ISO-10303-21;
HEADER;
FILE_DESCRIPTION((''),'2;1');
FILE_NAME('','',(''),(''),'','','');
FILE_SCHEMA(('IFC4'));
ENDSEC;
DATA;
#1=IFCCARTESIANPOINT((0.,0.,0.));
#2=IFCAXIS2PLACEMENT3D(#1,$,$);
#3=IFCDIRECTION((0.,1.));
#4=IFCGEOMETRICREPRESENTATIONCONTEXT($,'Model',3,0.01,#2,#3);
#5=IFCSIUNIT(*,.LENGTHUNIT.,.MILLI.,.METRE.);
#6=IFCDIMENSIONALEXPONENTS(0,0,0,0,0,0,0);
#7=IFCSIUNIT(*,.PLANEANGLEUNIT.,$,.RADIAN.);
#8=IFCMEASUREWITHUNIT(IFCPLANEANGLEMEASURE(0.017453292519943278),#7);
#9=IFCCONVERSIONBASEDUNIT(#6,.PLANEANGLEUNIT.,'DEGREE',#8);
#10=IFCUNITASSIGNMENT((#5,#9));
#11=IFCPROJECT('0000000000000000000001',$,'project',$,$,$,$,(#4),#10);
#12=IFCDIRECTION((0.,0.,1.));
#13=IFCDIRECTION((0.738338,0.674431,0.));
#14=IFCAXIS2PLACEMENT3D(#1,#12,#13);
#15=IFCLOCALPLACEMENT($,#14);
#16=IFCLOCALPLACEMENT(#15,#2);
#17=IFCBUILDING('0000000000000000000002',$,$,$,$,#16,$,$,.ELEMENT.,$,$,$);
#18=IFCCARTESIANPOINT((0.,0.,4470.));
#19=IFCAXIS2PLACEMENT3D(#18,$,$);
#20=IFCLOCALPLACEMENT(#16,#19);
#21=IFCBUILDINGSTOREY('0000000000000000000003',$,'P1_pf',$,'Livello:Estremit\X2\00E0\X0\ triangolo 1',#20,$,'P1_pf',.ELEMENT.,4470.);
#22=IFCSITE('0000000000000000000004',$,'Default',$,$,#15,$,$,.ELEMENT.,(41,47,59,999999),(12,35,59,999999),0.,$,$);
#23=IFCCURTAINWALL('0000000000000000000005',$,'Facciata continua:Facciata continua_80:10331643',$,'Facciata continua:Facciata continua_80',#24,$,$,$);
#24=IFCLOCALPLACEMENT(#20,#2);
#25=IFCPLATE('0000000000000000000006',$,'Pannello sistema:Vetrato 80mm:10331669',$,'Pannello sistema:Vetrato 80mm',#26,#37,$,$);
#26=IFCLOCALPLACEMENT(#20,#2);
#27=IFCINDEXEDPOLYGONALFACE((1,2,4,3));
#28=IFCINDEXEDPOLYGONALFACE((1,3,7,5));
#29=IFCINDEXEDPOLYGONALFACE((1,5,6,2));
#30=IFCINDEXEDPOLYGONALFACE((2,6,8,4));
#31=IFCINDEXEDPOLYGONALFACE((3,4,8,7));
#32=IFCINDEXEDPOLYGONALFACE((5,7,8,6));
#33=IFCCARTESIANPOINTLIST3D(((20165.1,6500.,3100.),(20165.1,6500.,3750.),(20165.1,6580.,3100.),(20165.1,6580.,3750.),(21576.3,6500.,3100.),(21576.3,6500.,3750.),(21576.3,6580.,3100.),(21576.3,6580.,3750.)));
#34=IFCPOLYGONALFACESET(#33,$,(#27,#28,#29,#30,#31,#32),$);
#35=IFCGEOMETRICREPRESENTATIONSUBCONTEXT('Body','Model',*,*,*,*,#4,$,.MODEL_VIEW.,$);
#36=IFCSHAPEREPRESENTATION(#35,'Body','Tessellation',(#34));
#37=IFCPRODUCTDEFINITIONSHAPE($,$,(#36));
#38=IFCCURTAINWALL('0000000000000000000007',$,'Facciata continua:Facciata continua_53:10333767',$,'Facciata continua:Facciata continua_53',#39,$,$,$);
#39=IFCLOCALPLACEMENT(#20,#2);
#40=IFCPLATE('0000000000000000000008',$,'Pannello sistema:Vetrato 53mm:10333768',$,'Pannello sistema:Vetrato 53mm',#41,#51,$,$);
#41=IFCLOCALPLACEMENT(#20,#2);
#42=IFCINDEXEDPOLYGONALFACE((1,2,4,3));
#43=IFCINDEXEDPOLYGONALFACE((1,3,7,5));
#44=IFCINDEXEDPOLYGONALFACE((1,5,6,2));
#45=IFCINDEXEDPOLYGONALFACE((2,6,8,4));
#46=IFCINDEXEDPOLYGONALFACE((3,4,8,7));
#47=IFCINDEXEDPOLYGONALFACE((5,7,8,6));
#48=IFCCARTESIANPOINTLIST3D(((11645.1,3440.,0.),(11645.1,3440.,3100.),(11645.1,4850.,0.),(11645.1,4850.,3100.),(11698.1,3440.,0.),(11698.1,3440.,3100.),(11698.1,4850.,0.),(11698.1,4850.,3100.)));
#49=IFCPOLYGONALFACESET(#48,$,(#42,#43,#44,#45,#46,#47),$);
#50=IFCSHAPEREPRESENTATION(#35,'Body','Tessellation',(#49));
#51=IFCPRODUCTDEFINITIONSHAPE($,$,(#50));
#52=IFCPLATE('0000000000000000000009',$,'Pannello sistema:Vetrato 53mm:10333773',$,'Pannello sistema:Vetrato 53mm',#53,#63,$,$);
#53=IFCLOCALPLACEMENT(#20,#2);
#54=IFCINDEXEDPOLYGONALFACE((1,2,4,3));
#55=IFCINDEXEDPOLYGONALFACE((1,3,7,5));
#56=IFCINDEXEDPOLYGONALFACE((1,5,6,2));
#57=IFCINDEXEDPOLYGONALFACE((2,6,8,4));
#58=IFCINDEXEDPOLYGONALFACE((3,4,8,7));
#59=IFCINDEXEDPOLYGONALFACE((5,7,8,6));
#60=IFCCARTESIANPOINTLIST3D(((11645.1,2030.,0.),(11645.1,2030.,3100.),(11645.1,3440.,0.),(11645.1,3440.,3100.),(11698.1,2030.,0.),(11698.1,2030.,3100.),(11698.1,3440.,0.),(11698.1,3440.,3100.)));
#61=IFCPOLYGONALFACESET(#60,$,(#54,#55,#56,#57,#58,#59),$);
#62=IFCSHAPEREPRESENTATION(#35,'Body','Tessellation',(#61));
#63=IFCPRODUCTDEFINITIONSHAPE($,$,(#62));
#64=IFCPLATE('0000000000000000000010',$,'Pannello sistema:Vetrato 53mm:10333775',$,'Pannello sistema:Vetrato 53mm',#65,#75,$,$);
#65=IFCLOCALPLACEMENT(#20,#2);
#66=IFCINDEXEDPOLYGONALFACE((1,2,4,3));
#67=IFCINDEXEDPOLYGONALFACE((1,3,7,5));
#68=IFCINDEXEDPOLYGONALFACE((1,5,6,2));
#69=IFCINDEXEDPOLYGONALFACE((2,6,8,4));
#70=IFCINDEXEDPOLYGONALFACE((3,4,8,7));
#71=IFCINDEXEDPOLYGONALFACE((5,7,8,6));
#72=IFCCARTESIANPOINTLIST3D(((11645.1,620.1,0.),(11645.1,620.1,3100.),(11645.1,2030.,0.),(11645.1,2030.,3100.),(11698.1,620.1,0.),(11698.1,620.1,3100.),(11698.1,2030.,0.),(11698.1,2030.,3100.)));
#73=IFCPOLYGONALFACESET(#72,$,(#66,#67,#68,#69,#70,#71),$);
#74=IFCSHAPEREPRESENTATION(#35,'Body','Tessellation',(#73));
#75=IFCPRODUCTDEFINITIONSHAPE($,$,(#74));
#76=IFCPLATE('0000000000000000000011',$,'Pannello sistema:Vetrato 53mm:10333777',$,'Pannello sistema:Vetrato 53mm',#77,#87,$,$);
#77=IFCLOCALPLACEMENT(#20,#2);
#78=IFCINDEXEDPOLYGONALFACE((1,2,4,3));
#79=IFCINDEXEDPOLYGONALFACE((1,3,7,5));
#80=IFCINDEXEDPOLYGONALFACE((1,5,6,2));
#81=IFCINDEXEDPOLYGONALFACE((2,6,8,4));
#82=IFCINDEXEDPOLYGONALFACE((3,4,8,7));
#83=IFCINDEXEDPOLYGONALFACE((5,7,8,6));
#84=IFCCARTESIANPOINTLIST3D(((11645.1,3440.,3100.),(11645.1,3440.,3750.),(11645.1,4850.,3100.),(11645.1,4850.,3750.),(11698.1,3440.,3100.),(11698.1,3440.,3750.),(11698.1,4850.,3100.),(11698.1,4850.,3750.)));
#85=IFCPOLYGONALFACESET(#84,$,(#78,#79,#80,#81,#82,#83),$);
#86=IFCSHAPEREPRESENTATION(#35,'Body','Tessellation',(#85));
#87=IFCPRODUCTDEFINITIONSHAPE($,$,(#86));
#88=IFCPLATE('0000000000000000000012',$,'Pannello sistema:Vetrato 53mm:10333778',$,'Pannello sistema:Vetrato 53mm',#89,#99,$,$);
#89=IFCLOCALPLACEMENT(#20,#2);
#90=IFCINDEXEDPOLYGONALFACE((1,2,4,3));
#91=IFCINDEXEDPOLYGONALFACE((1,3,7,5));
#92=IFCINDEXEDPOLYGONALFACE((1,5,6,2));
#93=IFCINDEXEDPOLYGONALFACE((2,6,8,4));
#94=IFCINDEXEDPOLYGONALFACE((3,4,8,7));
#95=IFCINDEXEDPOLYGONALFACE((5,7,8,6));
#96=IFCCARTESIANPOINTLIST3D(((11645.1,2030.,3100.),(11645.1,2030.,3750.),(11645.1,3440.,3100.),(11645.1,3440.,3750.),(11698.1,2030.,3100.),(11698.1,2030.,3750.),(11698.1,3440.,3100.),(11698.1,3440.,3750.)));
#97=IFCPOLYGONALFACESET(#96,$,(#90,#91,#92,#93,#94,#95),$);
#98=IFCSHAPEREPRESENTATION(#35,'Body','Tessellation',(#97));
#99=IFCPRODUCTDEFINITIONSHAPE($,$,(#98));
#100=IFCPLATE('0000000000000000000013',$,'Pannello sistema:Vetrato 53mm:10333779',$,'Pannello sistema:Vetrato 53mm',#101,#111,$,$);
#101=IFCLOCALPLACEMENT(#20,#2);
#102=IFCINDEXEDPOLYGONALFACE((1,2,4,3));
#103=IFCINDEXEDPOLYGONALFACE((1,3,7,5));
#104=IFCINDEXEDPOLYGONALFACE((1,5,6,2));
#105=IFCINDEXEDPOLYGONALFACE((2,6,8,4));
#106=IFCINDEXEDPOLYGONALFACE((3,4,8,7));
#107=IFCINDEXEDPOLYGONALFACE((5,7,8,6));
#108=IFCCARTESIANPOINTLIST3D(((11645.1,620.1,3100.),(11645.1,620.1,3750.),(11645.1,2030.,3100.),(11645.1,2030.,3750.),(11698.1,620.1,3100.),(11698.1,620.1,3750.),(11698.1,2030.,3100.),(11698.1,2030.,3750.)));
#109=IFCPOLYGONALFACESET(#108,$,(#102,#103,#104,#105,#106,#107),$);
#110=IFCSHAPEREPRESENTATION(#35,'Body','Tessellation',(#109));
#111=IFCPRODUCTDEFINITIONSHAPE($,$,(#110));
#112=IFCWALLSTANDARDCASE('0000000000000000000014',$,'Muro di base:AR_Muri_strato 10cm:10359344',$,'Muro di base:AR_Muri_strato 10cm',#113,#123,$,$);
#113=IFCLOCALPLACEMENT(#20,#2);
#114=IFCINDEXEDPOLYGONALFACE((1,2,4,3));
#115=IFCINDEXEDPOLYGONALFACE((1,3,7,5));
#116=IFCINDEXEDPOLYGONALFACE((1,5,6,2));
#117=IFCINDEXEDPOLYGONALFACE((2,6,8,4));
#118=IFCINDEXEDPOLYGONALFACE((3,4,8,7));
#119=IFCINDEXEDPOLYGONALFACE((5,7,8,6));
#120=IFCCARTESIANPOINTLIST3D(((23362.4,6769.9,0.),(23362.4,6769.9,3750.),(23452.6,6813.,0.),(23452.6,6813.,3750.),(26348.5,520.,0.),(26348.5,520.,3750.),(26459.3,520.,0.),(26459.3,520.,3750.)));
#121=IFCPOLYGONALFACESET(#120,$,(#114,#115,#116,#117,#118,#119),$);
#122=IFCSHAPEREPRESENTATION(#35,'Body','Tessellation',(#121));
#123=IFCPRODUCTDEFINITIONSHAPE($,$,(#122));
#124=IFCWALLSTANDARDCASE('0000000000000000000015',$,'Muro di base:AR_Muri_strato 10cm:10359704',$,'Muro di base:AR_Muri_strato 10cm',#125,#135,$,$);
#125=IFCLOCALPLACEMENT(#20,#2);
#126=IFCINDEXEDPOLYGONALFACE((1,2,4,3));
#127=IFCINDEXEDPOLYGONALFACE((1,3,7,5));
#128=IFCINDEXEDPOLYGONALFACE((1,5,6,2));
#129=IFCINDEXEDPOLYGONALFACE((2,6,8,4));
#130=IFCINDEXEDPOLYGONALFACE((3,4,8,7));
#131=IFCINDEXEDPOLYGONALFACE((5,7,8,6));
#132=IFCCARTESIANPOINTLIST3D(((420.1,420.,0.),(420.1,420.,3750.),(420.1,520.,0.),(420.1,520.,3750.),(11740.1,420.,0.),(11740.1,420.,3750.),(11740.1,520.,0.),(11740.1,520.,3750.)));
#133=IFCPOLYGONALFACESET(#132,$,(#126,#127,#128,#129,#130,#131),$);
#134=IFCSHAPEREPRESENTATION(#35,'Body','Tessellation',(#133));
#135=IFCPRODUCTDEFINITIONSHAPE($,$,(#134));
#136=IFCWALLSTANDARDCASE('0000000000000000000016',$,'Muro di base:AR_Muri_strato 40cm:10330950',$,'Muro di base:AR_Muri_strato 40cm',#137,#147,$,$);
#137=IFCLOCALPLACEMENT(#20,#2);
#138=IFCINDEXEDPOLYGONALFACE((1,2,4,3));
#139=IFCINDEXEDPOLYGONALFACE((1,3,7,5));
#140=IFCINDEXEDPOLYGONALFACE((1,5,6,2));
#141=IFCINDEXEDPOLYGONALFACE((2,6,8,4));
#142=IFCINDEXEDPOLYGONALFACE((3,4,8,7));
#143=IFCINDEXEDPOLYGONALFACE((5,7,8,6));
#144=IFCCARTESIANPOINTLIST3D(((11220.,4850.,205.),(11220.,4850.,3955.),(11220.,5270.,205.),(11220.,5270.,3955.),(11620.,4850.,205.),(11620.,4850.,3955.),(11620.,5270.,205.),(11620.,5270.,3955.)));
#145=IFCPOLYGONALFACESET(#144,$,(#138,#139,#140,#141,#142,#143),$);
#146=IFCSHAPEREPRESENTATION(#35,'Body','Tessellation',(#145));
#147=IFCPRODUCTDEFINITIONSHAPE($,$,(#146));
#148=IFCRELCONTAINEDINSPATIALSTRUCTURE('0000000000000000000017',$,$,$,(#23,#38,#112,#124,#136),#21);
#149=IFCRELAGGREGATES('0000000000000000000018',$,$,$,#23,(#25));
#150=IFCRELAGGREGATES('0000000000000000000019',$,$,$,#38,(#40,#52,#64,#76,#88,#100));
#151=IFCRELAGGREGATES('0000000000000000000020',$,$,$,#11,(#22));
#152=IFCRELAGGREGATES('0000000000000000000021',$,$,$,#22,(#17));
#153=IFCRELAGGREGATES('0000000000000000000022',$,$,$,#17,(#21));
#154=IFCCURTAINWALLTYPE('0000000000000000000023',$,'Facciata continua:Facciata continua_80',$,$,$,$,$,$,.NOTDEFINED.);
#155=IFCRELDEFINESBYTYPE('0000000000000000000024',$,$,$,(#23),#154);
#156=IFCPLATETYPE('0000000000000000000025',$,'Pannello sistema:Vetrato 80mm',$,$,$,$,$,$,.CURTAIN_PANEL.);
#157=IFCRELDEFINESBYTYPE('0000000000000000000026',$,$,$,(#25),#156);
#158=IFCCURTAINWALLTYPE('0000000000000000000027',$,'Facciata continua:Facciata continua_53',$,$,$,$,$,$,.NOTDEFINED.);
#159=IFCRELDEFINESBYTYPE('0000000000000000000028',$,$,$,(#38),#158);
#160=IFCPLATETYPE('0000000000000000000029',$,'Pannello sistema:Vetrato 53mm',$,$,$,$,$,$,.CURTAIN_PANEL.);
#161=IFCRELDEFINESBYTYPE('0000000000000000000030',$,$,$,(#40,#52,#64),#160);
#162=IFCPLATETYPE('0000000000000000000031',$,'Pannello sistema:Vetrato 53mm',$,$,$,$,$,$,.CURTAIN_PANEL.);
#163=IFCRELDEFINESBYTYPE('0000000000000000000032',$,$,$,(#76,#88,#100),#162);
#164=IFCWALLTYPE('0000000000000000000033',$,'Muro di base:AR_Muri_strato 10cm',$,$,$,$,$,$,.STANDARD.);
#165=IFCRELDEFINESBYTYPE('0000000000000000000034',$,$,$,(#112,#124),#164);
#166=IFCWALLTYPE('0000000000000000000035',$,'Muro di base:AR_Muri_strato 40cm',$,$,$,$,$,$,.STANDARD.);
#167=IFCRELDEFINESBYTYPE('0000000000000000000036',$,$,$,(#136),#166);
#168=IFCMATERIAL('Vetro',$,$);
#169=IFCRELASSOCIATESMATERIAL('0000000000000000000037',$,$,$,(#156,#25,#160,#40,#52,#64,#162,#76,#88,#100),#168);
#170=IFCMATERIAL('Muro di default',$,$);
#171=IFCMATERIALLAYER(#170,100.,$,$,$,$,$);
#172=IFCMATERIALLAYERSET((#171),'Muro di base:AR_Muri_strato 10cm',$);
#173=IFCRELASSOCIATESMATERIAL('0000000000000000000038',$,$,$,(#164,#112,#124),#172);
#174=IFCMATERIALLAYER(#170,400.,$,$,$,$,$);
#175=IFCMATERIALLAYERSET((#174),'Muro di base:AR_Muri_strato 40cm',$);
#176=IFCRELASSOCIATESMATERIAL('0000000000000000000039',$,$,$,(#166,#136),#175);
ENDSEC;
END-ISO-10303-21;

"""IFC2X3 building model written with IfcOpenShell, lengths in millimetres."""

from ifc_helpers import new_model, entity, si_unit, converted_unit, direction, frame, frame_2d, origin, origin_2d_with_axis, place, context, subcontext, project, spatial, polyline, rectangle, outline, extrude, source, transform, mapped, material, layer, layer_set, layer_usage, type_object, type_shapes, element, aggregate, save


model = new_model("IFC2X3")

# Units and contexts
model_context = context("Model", 3, precision=0.01, world=origin(), true_north=direction((0.0, 1.0)))
body_context = subcontext(model_context, "Body", "Model", "MODEL_VIEW")
ifc_project = project(units=[si_unit("LENGTHUNIT", "METRE", prefix="MILLI"), converted_unit("PLANEANGLEUNIT", "DEGREE", entity("IfcPlaneAngleMeasure", 0.017453292519943278), si_unit("PLANEANGLEUNIT", "RADIAN"), dimensions=[0, 0, 0, 0, 0, 0, 0])], contexts=[model_context])

# Site, building, storey
site_placement = place(None, frame((0.0, 0.0, 0.0), z_axis=(0.0, 0.0, 1.0), x_axis=(0.738338, 0.674431, 0.0)))
site = spatial("IfcSite", under=ifc_project, at=site_placement, Name="Default", CompositionType="ELEMENT", RefLatitude=(41, 47, 59, 999999), RefLongitude=(12, 35, 59, 999999), RefElevation=0.0)
building_placement = place(site_placement, origin())
building = spatial("IfcBuilding", under=site, at=building_placement, CompositionType="ELEMENT")
storey_placement = place(building_placement, frame((0.0, 0.0, 4470.0)))
storey = spatial("IfcBuildingStorey", under=building, at=storey_placement, Name="P1_pf", ObjectType="Livello:Estremità triangolo 1", LongName="P1_pf", CompositionType="ELEMENT", Elevation=4470.0)

# Shared definitions
ifc_material_1 = material(Name="Vetro")

# Curtain walls, plates
curtain_wall_type_1 = type_object("IfcCurtainWallType", Name="Facciata continua:Facciata continua_80", PredefinedType="NOTDEFINED")
curtain_wall_1_placement = place(storey_placement, frame((0.0, 0.0, -4470.0)))
curtain_wall_1 = element("IfcCurtainWall", 1, at=curtain_wall_1_placement, inside=storey, type_object=curtain_wall_type_1, Name="Facciata continua:Facciata continua_80:10331643", ObjectType="Facciata continua:Facciata continua_80")
plate_type_1 = type_object("IfcPlateType", Name="Pannello sistema:Vetrato 80mm", PredefinedType="CURTAIN_PANEL", material=ifc_material_1)
shared_shape_1 = source(origin(), body_context, "Body", "SweptSolid", [
    extrude(rectangle(XDim=80.0, YDim=1411.2, at=origin_2d_with_axis()), frame((0.0, -40.0, 0.0), z_axis=(0.0, 0.0, 1.0), x_axis=(0.0, 1.0, 0.0)), (0.0, 0.0, 1.0), 650.0),
])
type_shapes(plate_type_1, [shared_shape_1])
plate_1_placement = place(curtain_wall_1_placement, frame((20870.7, 6580.0, 7570.0)))
plate_1 = element("IfcPlate", 2, at=plate_1_placement, type_object=plate_type_1, material=ifc_material_1, Name="Pannello sistema:Vetrato 80mm:10331669", ObjectType="Pannello sistema:Vetrato 80mm", context=body_context, shape_type="MappedRepresentation", body=[
    mapped(shared_shape_1, transform((0.0, 0.0, 0.0), scale=1.0)),
])
aggregate(curtain_wall_1, [plate_1])
curtain_wall_type_2 = type_object("IfcCurtainWallType", Name="Facciata continua:Facciata continua_53", PredefinedType="NOTDEFINED")
curtain_wall_2_placement = place(storey_placement, frame((0.0, 0.0, -4470.0)))
curtain_wall_2 = element("IfcCurtainWall", 3, at=curtain_wall_2_placement, inside=storey, type_object=curtain_wall_type_2, Name="Facciata continua:Facciata continua_53:10333767", ObjectType="Facciata continua:Facciata continua_53")
plate_type_2 = type_object("IfcPlateType", Name="Pannello sistema:Vetrato 53mm", PredefinedType="CURTAIN_PANEL", material=ifc_material_1)
shared_shape_2 = source(origin(), body_context, "Body", "SweptSolid", [
    extrude(rectangle(XDim=53.0, YDim=1410.0, at=frame_2d((0.0, 0.0), x_axis=(1.0, 0.0))), frame((0.0, -26.5, 0.0), z_axis=(0.0, 0.0, 1.0), x_axis=(0.0, 1.0, 0.0)), (0.0, 0.0, 1.0), 3100.0),
])
type_shapes(plate_type_2, [shared_shape_2])
plate_2_placement = place(curtain_wall_2_placement, frame((11698.1, 4145.0, 4470.0), z_axis=(0.0, 0.0, 1.0), x_axis=(0.0, -1.0, 0.0)))
plate_2 = element("IfcPlate", 4, at=plate_2_placement, type_object=plate_type_2, material=ifc_material_1, Name="Pannello sistema:Vetrato 53mm:10333768", ObjectType="Pannello sistema:Vetrato 53mm", context=body_context, shape_type="MappedRepresentation", body=[
    mapped(shared_shape_2, transform((0.0, 0.0, 0.0), scale=1.0)),
])
plate_3_placement = place(curtain_wall_2_placement, frame((11698.1, 2735.0, 4470.0), z_axis=(0.0, 0.0, 1.0), x_axis=(0.0, -1.0, 0.0)))
plate_3 = element("IfcPlate", 5, at=plate_3_placement, type_object=plate_type_2, material=ifc_material_1, Name="Pannello sistema:Vetrato 53mm:10333773", ObjectType="Pannello sistema:Vetrato 53mm", context=body_context, shape_type="MappedRepresentation", body=[
    mapped(shared_shape_2, transform((0.0, 0.0, 0.0), scale=1.0)),
])
plate_4_placement = place(curtain_wall_2_placement, frame((11698.1, 1325.0, 4470.0), z_axis=(0.0, 0.0, 1.0), x_axis=(0.0, -1.0, 0.0)))
plate_4 = element("IfcPlate", 6, at=plate_4_placement, type_object=plate_type_2, material=ifc_material_1, Name="Pannello sistema:Vetrato 53mm:10333775", ObjectType="Pannello sistema:Vetrato 53mm", context=body_context, shape_type="MappedRepresentation", body=[
    mapped(shared_shape_2, transform((0.0, 0.0, 0.0), scale=1.0)),
])
plate_type_3 = type_object("IfcPlateType", Name="Pannello sistema:Vetrato 53mm", PredefinedType="CURTAIN_PANEL", material=ifc_material_1)
shared_shape_3 = source(origin(), body_context, "Body", "SweptSolid", [
    extrude(rectangle(XDim=53.0, YDim=1410.0, at=frame_2d((0.0, 0.0), x_axis=(1.0, 0.0))), frame((0.0, -26.5, 0.0), z_axis=(0.0, 0.0, 1.0), x_axis=(0.0, 1.0, 0.0)), (0.0, 0.0, 1.0), 650.0),
])
type_shapes(plate_type_3, [shared_shape_3])
plate_5_placement = place(curtain_wall_2_placement, frame((11698.1, 4145.0, 7570.0), z_axis=(0.0, 0.0, 1.0), x_axis=(0.0, -1.0, 0.0)))
plate_5 = element("IfcPlate", 7, at=plate_5_placement, type_object=plate_type_3, material=ifc_material_1, Name="Pannello sistema:Vetrato 53mm:10333777", ObjectType="Pannello sistema:Vetrato 53mm", context=body_context, shape_type="MappedRepresentation", body=[
    mapped(shared_shape_3, transform((0.0, 0.0, 0.0), scale=1.0)),
])
plate_6_placement = place(curtain_wall_2_placement, frame((11698.1, 2735.0, 7570.0), z_axis=(0.0, 0.0, 1.0), x_axis=(0.0, -1.0, 0.0)))
plate_6 = element("IfcPlate", 8, at=plate_6_placement, type_object=plate_type_3, material=ifc_material_1, Name="Pannello sistema:Vetrato 53mm:10333778", ObjectType="Pannello sistema:Vetrato 53mm", context=body_context, shape_type="MappedRepresentation", body=[
    mapped(shared_shape_3, transform((0.0, 0.0, 0.0), scale=1.0)),
])
plate_7_placement = place(curtain_wall_2_placement, frame((11698.1, 1325.0, 7570.0), z_axis=(0.0, 0.0, 1.0), x_axis=(0.0, -1.0, 0.0)))
plate_7 = element("IfcPlate", 9, at=plate_7_placement, type_object=plate_type_3, material=ifc_material_1, Name="Pannello sistema:Vetrato 53mm:10333779", ObjectType="Pannello sistema:Vetrato 53mm", context=body_context, shape_type="MappedRepresentation", body=[
    mapped(shared_shape_3, transform((0.0, 0.0, 0.0), scale=1.0)),
])
aggregate(curtain_wall_2, [plate_2, plate_3, plate_4, plate_5, plate_6, plate_7])

# Walls
ifc_material_2 = material(Name="Muro di default")
ifc_layer_1 = layer(ifc_material_2, 100.0)
ifc_layer_set_1 = layer_set([ifc_layer_1], Name="Muro di base:AR_Muri_strato 10cm")
ifc_layer_usage_1 = layer_usage(ifc_layer_set_1, "AXIS2", "NEGATIVE", 50.0)
wall_type_1 = type_object("IfcWallType", Name="Muro di base:AR_Muri_strato 10cm", PredefinedType="STANDARD", material=ifc_layer_set_1)
wall_1_placement = place(storey_placement, frame((26414.2, 498.4, 0.0), z_axis=(0.0, 0.0, 1.0), x_axis=(-0.431105, 0.902302, 0.0)))
element("IfcWallStandardCase", 10, at=wall_1_placement, inside=storey, type_object=wall_type_1, material=ifc_layer_usage_1, Name="Muro di base:AR_Muri_strato 10cm:10359344", ObjectType="Muro di base:AR_Muri_strato 10cm", context=body_context, shape_type="SweptSolid", body=[
    extrude(outline(polyline([(6974.4, -50.0), (6974.4, 50.0), (47.8, 50.0), (0.0, -50.0), (6974.4, -50.0)])), origin(), (0.0, 0.0, 1.0), 3750.0),
])
ifc_layer_usage_2 = layer_usage(ifc_layer_set_1, "AXIS2", "NEGATIVE", 50.0)
wall_2_placement = place(storey_placement, frame((11740.1, 470.0, 0.0), z_axis=(0.0, 0.0, 1.0), x_axis=(-1.0, 0.0, 0.0)))
element("IfcWallStandardCase", 11, at=wall_2_placement, inside=storey, type_object=wall_type_1, material=ifc_layer_usage_2, Name="Muro di base:AR_Muri_strato 10cm:10359704", ObjectType="Muro di base:AR_Muri_strato 10cm", context=body_context, shape_type="SweptSolid", body=[
    extrude(rectangle(XDim=11320.0, YDim=100.0, at=frame_2d((5660.0, 0.0), x_axis=(-1.0, 0.0))), origin(), (0.0, 0.0, 1.0), 3750.0),
])
ifc_layer_2 = layer(ifc_material_2, 400.0)
ifc_layer_set_2 = layer_set([ifc_layer_2], Name="Muro di base:AR_Muri_strato 40cm")
ifc_layer_usage_3 = layer_usage(ifc_layer_set_2, "AXIS2", "NEGATIVE", 200.0)
wall_type_2 = type_object("IfcWallType", Name="Muro di base:AR_Muri_strato 40cm", PredefinedType="STANDARD", material=ifc_layer_set_2)
wall_3_placement = place(storey_placement, frame((11420.0, 4850.0, 205.0), z_axis=(0.0, 0.0, 1.0), x_axis=(0.0, 1.0, 0.0)))
element("IfcWallStandardCase", 12, at=wall_3_placement, inside=storey, type_object=wall_type_2, material=ifc_layer_usage_3, Name="Muro di base:AR_Muri_strato 40cm:10330950", ObjectType="Muro di base:AR_Muri_strato 40cm", context=body_context, shape_type="SweptSolid", body=[
    extrude(rectangle(XDim=420.0, YDim=400.0, at=frame_2d((210.0, 0.0), x_axis=(-1.0, 0.0))), origin(), (0.0, 0.0, 1.0), 3750.0),
])

save(model, "model.ifc")
